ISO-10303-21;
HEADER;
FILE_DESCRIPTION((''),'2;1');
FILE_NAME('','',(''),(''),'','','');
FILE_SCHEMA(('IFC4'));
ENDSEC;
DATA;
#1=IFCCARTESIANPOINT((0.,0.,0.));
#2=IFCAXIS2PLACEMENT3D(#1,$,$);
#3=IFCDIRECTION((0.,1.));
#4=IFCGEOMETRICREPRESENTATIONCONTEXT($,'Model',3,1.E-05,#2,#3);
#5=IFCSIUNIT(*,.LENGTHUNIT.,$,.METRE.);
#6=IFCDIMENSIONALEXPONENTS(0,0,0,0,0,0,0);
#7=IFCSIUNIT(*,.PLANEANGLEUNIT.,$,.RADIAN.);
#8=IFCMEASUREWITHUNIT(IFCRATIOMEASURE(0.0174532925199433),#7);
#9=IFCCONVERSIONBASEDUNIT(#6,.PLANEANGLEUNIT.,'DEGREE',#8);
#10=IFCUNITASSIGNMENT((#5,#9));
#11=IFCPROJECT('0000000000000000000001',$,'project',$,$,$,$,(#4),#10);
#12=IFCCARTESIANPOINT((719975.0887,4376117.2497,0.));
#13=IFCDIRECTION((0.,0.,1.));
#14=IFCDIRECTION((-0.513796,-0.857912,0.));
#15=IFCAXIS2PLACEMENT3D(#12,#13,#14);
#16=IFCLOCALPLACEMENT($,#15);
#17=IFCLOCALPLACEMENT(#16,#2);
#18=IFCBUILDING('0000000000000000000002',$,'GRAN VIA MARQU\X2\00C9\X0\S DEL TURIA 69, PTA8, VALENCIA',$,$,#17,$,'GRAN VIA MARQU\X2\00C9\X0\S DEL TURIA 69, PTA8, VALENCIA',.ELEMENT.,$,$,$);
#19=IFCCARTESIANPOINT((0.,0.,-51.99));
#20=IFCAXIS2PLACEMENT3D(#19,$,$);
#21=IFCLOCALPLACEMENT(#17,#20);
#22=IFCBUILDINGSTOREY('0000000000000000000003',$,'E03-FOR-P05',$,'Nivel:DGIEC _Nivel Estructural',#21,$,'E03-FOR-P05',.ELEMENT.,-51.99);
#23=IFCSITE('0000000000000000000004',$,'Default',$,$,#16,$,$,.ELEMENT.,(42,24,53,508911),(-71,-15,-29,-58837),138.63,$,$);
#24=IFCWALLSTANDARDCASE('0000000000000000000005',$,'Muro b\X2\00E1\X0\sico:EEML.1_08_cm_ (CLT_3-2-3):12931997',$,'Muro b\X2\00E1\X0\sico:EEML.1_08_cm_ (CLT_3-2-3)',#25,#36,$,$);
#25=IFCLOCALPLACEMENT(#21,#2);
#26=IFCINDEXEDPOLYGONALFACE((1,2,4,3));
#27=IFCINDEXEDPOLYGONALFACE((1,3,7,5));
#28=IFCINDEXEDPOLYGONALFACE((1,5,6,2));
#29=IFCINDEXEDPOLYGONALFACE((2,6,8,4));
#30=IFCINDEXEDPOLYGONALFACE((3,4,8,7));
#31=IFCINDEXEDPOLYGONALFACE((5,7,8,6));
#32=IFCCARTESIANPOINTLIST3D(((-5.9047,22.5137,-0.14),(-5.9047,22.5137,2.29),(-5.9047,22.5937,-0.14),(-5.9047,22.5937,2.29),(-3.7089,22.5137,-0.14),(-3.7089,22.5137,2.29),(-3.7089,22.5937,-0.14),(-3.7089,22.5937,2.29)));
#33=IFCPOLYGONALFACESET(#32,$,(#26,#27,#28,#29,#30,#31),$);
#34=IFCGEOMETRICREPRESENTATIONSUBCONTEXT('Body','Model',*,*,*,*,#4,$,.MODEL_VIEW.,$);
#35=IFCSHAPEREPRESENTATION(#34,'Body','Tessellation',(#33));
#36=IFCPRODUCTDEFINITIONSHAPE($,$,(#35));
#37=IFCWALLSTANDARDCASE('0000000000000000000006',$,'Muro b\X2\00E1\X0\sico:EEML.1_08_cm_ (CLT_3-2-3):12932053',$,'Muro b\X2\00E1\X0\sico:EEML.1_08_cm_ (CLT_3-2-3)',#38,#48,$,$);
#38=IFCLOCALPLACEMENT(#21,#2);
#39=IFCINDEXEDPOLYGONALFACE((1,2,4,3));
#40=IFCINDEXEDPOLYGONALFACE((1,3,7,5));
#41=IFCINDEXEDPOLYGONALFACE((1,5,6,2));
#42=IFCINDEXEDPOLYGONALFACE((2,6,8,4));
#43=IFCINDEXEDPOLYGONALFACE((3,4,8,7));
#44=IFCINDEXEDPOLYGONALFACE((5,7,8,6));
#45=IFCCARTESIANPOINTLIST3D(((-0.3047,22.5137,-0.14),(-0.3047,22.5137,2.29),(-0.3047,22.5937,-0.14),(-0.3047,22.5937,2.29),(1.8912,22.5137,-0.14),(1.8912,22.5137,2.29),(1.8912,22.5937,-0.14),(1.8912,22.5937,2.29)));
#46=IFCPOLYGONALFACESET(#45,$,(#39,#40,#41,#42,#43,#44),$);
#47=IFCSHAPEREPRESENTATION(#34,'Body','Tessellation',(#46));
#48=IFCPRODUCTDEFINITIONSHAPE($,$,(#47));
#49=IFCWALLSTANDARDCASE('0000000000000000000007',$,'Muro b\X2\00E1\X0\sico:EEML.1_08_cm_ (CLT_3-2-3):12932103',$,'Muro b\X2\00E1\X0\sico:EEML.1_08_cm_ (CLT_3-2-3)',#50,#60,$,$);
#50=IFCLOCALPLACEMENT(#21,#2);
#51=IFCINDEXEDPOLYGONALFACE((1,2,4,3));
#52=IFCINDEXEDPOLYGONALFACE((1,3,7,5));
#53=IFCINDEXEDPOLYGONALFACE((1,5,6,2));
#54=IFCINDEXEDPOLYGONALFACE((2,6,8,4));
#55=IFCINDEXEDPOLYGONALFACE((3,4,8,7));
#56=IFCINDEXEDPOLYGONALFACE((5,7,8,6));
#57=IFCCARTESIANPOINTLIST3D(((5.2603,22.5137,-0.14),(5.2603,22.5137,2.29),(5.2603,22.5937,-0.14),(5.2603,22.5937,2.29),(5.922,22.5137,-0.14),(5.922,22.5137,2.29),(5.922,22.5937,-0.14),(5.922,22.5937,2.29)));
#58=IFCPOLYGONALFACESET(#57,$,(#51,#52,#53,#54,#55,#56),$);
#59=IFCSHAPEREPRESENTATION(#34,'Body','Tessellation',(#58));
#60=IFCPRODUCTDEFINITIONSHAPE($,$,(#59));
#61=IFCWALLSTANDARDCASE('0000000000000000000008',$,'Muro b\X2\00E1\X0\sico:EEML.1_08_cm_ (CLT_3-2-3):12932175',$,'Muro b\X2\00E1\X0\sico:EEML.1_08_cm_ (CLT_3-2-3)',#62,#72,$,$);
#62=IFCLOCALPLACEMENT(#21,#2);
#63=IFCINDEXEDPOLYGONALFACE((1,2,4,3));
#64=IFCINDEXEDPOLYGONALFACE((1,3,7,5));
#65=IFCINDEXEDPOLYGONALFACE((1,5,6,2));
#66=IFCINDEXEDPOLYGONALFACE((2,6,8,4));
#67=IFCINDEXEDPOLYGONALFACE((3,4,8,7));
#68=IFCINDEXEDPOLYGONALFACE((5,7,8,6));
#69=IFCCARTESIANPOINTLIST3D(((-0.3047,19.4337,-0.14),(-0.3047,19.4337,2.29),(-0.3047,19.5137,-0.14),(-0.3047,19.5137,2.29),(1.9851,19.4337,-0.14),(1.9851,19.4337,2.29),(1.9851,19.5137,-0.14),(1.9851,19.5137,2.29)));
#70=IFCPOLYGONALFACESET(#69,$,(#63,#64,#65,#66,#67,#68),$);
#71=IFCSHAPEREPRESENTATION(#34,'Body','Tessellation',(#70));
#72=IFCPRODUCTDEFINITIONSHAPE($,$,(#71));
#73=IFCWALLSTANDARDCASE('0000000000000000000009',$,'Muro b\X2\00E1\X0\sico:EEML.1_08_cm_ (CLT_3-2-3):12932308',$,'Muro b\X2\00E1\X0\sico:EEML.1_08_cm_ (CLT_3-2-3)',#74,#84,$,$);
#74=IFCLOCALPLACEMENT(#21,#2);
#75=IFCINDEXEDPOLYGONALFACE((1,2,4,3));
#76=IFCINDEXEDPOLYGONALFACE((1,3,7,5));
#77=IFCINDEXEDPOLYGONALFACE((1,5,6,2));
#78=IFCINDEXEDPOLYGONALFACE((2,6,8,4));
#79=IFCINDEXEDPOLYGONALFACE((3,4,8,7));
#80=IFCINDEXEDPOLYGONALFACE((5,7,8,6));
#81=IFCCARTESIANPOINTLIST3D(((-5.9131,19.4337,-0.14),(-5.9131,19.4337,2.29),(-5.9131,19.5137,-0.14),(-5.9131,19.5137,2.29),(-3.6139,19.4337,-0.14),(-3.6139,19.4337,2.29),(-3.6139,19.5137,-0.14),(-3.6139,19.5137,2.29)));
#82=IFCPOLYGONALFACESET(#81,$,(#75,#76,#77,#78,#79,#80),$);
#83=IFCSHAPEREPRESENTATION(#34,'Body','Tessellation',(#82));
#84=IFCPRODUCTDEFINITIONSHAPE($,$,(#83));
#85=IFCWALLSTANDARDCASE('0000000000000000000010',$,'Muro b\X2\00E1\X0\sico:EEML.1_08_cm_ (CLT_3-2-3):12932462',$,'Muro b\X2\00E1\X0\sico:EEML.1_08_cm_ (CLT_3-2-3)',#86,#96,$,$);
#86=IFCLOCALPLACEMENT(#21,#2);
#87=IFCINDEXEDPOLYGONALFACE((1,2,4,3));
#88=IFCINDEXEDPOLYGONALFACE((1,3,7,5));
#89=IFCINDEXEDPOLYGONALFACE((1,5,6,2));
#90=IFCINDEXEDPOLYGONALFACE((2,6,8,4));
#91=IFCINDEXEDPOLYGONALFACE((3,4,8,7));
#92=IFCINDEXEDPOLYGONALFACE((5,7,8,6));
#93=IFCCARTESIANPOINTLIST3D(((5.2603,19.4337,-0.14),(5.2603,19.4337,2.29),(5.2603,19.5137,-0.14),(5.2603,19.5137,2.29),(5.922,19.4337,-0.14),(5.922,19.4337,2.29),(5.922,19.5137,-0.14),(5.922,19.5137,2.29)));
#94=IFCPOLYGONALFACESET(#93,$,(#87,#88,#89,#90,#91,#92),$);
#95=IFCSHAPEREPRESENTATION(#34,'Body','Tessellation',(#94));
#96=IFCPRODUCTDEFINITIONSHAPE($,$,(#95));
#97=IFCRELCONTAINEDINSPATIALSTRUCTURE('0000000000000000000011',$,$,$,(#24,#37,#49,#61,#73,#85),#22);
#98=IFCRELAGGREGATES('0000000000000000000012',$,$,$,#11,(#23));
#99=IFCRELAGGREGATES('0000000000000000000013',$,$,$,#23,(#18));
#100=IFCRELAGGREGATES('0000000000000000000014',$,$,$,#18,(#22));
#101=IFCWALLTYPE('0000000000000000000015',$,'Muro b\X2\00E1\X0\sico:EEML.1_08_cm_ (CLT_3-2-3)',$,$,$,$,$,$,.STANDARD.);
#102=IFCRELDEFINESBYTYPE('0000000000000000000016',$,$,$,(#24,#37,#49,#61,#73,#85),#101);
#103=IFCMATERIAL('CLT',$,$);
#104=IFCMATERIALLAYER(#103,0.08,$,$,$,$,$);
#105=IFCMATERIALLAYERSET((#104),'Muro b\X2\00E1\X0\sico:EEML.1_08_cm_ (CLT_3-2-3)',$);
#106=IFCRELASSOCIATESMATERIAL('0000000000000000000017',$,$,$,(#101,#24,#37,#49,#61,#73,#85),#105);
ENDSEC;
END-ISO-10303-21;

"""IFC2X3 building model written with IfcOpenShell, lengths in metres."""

from ifc_helpers import new_model, entity, si_unit, converted_unit, direction, frame, frame_2d, origin, place, context, subcontext, project, spatial, rectangle, extrude, material, layer, layer_set, layer_usage, type_object, element, save


model = new_model("IFC2X3")

# Units and contexts
model_context = context("Model", 3, precision=1e-05, world=origin(), true_north=direction((0.0, 1.0)))
body_context = subcontext(model_context, "Body", "Model", "MODEL_VIEW")
ifc_project = project(units=[si_unit("LENGTHUNIT", "METRE"), converted_unit("PLANEANGLEUNIT", "DEGREE", entity("IfcRatioMeasure", 0.0174532925199433), si_unit("PLANEANGLEUNIT", "RADIAN"), dimensions=[0, 0, 0, 0, 0, 0, 0])], contexts=[model_context])

# Site, building, storey
site_placement = place(None, frame((719975.0887, 4376117.2497, 0.0), z_axis=(0.0, 0.0, 1.0), x_axis=(-0.513796, -0.857912, 0.0)))
site = spatial("IfcSite", under=ifc_project, at=site_placement, Name="Default", CompositionType="ELEMENT", RefLatitude=(42, 24, 53, 508911), RefLongitude=(-71, -15, -29, -58837), RefElevation=138.63)
building_placement = place(site_placement, origin())
building = spatial("IfcBuilding", under=site, at=building_placement, Name="GRAN VIA MARQUÉS DEL TURIA 69, PTA8, VALENCIA", LongName="GRAN VIA MARQUÉS DEL TURIA 69, PTA8, VALENCIA", CompositionType="ELEMENT")
storey_placement = place(building_placement, frame((0.0, 0.0, -51.99)))
storey = spatial("IfcBuildingStorey", under=building, at=storey_placement, Name="E03-FOR-P05", ObjectType="Nivel:DGIEC _Nivel Estructural", LongName="E03-FOR-P05", CompositionType="ELEMENT", Elevation=-51.99)

# Walls
ifc_material_1 = material(Name="CLT")
ifc_layer_1 = layer(ifc_material_1, 0.08)
ifc_layer_set_1 = layer_set([ifc_layer_1], Name="Muro básico:EEML.1_08_cm_ (CLT_3-2-3)")
ifc_layer_usage_1 = layer_usage(ifc_layer_set_1, "AXIS2", "NEGATIVE", 0.04)
wall_type = type_object("IfcWallType", Name="Muro básico:EEML.1_08_cm_ (CLT_3-2-3)", PredefinedType="STANDARD", material=ifc_layer_set_1)
wall_1_placement = place(storey_placement, frame((-3.7089, 22.5537, -0.14), z_axis=(0.0, 0.0, 1.0), x_axis=(-1.0, 0.0, 0.0)))
element("IfcWallStandardCase", 1, at=wall_1_placement, inside=storey, type_object=wall_type, material=ifc_layer_usage_1, Name="Muro básico:EEML.1_08_cm_ (CLT_3-2-3):12931997", ObjectType="Muro básico:EEML.1_08_cm_ (CLT_3-2-3)", context=body_context, shape_type="SweptSolid", body=[
    extrude(rectangle(XDim=2.1959, YDim=0.08, at=frame_2d((1.0979, 0.0), x_axis=(-1.0, 0.0))), origin(), (0.0, 0.0, 1.0), 2.43),
])
ifc_layer_usage_2 = layer_usage(ifc_layer_set_1, "AXIS2", "NEGATIVE", 0.04)
wall_2_placement = place(storey_placement, frame((1.8912, 22.5537, -0.14), z_axis=(0.0, 0.0, 1.0), x_axis=(-1.0, 0.0, 0.0)))
element("IfcWallStandardCase", 2, at=wall_2_placement, inside=storey, type_object=wall_type, material=ifc_layer_usage_2, Name="Muro básico:EEML.1_08_cm_ (CLT_3-2-3):12932053", ObjectType="Muro básico:EEML.1_08_cm_ (CLT_3-2-3)", context=body_context, shape_type="SweptSolid", body=[
    extrude(rectangle(XDim=2.1959, YDim=0.08, at=frame_2d((1.0979, 0.0), x_axis=(-1.0, 0.0))), origin(), (0.0, 0.0, 1.0), 2.43),
])
ifc_layer_usage_3 = layer_usage(ifc_layer_set_1, "AXIS2", "NEGATIVE", 0.04)
wall_3_placement = place(storey_placement, frame((5.922, 22.5537, -0.14), z_axis=(0.0, 0.0, 1.0), x_axis=(-1.0, 0.0, 0.0)))
element("IfcWallStandardCase", 3, at=wall_3_placement, inside=storey, type_object=wall_type, material=ifc_layer_usage_3, Name="Muro básico:EEML.1_08_cm_ (CLT_3-2-3):12932103", ObjectType="Muro básico:EEML.1_08_cm_ (CLT_3-2-3)", context=body_context, shape_type="SweptSolid", body=[
    extrude(rectangle(XDim=0.6617, YDim=0.08, at=frame_2d((0.3308, 0.0), x_axis=(-1.0, 0.0))), origin(), (0.0, 0.0, 1.0), 2.43),
])
ifc_layer_usage_4 = layer_usage(ifc_layer_set_1, "AXIS2", "NEGATIVE", 0.04)
wall_4_placement = place(storey_placement, frame((1.9851, 19.4737, -0.14), z_axis=(0.0, 0.0, 1.0), x_axis=(-1.0, 0.0, 0.0)))
element("IfcWallStandardCase", 4, at=wall_4_placement, inside=storey, type_object=wall_type, material=ifc_layer_usage_4, Name="Muro básico:EEML.1_08_cm_ (CLT_3-2-3):12932175", ObjectType="Muro básico:EEML.1_08_cm_ (CLT_3-2-3)", context=body_context, shape_type="SweptSolid", body=[
    extrude(rectangle(XDim=2.2898, YDim=0.08, at=frame_2d((1.1449, 0.0), x_axis=(-1.0, 0.0))), origin(), (0.0, 0.0, 1.0), 2.43),
])
ifc_layer_usage_5 = layer_usage(ifc_layer_set_1, "AXIS2", "NEGATIVE", 0.04)
wall_5_placement = place(storey_placement, frame((-3.6139, 19.4737, -0.14), z_axis=(0.0, 0.0, 1.0), x_axis=(-1.0, 0.0, 0.0)))
element("IfcWallStandardCase", 5, at=wall_5_placement, inside=storey, type_object=wall_type, material=ifc_layer_usage_5, Name="Muro básico:EEML.1_08_cm_ (CLT_3-2-3):12932308", ObjectType="Muro básico:EEML.1_08_cm_ (CLT_3-2-3)", context=body_context, shape_type="SweptSolid", body=[
    extrude(rectangle(XDim=2.2992, YDim=0.08, at=frame_2d((1.1496, 0.0), x_axis=(-1.0, 0.0))), origin(), (0.0, 0.0, 1.0), 2.43),
])
ifc_layer_usage_6 = layer_usage(ifc_layer_set_1, "AXIS2", "NEGATIVE", 0.04)
wall_6_placement = place(storey_placement, frame((5.922, 19.4737, -0.14), z_axis=(0.0, 0.0, 1.0), x_axis=(-1.0, 0.0, 0.0)))
element("IfcWallStandardCase", 6, at=wall_6_placement, inside=storey, type_object=wall_type, material=ifc_layer_usage_6, Name="Muro básico:EEML.1_08_cm_ (CLT_3-2-3):12932462", ObjectType="Muro básico:EEML.1_08_cm_ (CLT_3-2-3)", context=body_context, shape_type="SweptSolid", body=[
    extrude(rectangle(XDim=0.6617, YDim=0.08, at=frame_2d((0.3308, 0.0), x_axis=(-1.0, 0.0))), origin(), (0.0, 0.0, 1.0), 2.43),
])

save(model, "model.ifc")
